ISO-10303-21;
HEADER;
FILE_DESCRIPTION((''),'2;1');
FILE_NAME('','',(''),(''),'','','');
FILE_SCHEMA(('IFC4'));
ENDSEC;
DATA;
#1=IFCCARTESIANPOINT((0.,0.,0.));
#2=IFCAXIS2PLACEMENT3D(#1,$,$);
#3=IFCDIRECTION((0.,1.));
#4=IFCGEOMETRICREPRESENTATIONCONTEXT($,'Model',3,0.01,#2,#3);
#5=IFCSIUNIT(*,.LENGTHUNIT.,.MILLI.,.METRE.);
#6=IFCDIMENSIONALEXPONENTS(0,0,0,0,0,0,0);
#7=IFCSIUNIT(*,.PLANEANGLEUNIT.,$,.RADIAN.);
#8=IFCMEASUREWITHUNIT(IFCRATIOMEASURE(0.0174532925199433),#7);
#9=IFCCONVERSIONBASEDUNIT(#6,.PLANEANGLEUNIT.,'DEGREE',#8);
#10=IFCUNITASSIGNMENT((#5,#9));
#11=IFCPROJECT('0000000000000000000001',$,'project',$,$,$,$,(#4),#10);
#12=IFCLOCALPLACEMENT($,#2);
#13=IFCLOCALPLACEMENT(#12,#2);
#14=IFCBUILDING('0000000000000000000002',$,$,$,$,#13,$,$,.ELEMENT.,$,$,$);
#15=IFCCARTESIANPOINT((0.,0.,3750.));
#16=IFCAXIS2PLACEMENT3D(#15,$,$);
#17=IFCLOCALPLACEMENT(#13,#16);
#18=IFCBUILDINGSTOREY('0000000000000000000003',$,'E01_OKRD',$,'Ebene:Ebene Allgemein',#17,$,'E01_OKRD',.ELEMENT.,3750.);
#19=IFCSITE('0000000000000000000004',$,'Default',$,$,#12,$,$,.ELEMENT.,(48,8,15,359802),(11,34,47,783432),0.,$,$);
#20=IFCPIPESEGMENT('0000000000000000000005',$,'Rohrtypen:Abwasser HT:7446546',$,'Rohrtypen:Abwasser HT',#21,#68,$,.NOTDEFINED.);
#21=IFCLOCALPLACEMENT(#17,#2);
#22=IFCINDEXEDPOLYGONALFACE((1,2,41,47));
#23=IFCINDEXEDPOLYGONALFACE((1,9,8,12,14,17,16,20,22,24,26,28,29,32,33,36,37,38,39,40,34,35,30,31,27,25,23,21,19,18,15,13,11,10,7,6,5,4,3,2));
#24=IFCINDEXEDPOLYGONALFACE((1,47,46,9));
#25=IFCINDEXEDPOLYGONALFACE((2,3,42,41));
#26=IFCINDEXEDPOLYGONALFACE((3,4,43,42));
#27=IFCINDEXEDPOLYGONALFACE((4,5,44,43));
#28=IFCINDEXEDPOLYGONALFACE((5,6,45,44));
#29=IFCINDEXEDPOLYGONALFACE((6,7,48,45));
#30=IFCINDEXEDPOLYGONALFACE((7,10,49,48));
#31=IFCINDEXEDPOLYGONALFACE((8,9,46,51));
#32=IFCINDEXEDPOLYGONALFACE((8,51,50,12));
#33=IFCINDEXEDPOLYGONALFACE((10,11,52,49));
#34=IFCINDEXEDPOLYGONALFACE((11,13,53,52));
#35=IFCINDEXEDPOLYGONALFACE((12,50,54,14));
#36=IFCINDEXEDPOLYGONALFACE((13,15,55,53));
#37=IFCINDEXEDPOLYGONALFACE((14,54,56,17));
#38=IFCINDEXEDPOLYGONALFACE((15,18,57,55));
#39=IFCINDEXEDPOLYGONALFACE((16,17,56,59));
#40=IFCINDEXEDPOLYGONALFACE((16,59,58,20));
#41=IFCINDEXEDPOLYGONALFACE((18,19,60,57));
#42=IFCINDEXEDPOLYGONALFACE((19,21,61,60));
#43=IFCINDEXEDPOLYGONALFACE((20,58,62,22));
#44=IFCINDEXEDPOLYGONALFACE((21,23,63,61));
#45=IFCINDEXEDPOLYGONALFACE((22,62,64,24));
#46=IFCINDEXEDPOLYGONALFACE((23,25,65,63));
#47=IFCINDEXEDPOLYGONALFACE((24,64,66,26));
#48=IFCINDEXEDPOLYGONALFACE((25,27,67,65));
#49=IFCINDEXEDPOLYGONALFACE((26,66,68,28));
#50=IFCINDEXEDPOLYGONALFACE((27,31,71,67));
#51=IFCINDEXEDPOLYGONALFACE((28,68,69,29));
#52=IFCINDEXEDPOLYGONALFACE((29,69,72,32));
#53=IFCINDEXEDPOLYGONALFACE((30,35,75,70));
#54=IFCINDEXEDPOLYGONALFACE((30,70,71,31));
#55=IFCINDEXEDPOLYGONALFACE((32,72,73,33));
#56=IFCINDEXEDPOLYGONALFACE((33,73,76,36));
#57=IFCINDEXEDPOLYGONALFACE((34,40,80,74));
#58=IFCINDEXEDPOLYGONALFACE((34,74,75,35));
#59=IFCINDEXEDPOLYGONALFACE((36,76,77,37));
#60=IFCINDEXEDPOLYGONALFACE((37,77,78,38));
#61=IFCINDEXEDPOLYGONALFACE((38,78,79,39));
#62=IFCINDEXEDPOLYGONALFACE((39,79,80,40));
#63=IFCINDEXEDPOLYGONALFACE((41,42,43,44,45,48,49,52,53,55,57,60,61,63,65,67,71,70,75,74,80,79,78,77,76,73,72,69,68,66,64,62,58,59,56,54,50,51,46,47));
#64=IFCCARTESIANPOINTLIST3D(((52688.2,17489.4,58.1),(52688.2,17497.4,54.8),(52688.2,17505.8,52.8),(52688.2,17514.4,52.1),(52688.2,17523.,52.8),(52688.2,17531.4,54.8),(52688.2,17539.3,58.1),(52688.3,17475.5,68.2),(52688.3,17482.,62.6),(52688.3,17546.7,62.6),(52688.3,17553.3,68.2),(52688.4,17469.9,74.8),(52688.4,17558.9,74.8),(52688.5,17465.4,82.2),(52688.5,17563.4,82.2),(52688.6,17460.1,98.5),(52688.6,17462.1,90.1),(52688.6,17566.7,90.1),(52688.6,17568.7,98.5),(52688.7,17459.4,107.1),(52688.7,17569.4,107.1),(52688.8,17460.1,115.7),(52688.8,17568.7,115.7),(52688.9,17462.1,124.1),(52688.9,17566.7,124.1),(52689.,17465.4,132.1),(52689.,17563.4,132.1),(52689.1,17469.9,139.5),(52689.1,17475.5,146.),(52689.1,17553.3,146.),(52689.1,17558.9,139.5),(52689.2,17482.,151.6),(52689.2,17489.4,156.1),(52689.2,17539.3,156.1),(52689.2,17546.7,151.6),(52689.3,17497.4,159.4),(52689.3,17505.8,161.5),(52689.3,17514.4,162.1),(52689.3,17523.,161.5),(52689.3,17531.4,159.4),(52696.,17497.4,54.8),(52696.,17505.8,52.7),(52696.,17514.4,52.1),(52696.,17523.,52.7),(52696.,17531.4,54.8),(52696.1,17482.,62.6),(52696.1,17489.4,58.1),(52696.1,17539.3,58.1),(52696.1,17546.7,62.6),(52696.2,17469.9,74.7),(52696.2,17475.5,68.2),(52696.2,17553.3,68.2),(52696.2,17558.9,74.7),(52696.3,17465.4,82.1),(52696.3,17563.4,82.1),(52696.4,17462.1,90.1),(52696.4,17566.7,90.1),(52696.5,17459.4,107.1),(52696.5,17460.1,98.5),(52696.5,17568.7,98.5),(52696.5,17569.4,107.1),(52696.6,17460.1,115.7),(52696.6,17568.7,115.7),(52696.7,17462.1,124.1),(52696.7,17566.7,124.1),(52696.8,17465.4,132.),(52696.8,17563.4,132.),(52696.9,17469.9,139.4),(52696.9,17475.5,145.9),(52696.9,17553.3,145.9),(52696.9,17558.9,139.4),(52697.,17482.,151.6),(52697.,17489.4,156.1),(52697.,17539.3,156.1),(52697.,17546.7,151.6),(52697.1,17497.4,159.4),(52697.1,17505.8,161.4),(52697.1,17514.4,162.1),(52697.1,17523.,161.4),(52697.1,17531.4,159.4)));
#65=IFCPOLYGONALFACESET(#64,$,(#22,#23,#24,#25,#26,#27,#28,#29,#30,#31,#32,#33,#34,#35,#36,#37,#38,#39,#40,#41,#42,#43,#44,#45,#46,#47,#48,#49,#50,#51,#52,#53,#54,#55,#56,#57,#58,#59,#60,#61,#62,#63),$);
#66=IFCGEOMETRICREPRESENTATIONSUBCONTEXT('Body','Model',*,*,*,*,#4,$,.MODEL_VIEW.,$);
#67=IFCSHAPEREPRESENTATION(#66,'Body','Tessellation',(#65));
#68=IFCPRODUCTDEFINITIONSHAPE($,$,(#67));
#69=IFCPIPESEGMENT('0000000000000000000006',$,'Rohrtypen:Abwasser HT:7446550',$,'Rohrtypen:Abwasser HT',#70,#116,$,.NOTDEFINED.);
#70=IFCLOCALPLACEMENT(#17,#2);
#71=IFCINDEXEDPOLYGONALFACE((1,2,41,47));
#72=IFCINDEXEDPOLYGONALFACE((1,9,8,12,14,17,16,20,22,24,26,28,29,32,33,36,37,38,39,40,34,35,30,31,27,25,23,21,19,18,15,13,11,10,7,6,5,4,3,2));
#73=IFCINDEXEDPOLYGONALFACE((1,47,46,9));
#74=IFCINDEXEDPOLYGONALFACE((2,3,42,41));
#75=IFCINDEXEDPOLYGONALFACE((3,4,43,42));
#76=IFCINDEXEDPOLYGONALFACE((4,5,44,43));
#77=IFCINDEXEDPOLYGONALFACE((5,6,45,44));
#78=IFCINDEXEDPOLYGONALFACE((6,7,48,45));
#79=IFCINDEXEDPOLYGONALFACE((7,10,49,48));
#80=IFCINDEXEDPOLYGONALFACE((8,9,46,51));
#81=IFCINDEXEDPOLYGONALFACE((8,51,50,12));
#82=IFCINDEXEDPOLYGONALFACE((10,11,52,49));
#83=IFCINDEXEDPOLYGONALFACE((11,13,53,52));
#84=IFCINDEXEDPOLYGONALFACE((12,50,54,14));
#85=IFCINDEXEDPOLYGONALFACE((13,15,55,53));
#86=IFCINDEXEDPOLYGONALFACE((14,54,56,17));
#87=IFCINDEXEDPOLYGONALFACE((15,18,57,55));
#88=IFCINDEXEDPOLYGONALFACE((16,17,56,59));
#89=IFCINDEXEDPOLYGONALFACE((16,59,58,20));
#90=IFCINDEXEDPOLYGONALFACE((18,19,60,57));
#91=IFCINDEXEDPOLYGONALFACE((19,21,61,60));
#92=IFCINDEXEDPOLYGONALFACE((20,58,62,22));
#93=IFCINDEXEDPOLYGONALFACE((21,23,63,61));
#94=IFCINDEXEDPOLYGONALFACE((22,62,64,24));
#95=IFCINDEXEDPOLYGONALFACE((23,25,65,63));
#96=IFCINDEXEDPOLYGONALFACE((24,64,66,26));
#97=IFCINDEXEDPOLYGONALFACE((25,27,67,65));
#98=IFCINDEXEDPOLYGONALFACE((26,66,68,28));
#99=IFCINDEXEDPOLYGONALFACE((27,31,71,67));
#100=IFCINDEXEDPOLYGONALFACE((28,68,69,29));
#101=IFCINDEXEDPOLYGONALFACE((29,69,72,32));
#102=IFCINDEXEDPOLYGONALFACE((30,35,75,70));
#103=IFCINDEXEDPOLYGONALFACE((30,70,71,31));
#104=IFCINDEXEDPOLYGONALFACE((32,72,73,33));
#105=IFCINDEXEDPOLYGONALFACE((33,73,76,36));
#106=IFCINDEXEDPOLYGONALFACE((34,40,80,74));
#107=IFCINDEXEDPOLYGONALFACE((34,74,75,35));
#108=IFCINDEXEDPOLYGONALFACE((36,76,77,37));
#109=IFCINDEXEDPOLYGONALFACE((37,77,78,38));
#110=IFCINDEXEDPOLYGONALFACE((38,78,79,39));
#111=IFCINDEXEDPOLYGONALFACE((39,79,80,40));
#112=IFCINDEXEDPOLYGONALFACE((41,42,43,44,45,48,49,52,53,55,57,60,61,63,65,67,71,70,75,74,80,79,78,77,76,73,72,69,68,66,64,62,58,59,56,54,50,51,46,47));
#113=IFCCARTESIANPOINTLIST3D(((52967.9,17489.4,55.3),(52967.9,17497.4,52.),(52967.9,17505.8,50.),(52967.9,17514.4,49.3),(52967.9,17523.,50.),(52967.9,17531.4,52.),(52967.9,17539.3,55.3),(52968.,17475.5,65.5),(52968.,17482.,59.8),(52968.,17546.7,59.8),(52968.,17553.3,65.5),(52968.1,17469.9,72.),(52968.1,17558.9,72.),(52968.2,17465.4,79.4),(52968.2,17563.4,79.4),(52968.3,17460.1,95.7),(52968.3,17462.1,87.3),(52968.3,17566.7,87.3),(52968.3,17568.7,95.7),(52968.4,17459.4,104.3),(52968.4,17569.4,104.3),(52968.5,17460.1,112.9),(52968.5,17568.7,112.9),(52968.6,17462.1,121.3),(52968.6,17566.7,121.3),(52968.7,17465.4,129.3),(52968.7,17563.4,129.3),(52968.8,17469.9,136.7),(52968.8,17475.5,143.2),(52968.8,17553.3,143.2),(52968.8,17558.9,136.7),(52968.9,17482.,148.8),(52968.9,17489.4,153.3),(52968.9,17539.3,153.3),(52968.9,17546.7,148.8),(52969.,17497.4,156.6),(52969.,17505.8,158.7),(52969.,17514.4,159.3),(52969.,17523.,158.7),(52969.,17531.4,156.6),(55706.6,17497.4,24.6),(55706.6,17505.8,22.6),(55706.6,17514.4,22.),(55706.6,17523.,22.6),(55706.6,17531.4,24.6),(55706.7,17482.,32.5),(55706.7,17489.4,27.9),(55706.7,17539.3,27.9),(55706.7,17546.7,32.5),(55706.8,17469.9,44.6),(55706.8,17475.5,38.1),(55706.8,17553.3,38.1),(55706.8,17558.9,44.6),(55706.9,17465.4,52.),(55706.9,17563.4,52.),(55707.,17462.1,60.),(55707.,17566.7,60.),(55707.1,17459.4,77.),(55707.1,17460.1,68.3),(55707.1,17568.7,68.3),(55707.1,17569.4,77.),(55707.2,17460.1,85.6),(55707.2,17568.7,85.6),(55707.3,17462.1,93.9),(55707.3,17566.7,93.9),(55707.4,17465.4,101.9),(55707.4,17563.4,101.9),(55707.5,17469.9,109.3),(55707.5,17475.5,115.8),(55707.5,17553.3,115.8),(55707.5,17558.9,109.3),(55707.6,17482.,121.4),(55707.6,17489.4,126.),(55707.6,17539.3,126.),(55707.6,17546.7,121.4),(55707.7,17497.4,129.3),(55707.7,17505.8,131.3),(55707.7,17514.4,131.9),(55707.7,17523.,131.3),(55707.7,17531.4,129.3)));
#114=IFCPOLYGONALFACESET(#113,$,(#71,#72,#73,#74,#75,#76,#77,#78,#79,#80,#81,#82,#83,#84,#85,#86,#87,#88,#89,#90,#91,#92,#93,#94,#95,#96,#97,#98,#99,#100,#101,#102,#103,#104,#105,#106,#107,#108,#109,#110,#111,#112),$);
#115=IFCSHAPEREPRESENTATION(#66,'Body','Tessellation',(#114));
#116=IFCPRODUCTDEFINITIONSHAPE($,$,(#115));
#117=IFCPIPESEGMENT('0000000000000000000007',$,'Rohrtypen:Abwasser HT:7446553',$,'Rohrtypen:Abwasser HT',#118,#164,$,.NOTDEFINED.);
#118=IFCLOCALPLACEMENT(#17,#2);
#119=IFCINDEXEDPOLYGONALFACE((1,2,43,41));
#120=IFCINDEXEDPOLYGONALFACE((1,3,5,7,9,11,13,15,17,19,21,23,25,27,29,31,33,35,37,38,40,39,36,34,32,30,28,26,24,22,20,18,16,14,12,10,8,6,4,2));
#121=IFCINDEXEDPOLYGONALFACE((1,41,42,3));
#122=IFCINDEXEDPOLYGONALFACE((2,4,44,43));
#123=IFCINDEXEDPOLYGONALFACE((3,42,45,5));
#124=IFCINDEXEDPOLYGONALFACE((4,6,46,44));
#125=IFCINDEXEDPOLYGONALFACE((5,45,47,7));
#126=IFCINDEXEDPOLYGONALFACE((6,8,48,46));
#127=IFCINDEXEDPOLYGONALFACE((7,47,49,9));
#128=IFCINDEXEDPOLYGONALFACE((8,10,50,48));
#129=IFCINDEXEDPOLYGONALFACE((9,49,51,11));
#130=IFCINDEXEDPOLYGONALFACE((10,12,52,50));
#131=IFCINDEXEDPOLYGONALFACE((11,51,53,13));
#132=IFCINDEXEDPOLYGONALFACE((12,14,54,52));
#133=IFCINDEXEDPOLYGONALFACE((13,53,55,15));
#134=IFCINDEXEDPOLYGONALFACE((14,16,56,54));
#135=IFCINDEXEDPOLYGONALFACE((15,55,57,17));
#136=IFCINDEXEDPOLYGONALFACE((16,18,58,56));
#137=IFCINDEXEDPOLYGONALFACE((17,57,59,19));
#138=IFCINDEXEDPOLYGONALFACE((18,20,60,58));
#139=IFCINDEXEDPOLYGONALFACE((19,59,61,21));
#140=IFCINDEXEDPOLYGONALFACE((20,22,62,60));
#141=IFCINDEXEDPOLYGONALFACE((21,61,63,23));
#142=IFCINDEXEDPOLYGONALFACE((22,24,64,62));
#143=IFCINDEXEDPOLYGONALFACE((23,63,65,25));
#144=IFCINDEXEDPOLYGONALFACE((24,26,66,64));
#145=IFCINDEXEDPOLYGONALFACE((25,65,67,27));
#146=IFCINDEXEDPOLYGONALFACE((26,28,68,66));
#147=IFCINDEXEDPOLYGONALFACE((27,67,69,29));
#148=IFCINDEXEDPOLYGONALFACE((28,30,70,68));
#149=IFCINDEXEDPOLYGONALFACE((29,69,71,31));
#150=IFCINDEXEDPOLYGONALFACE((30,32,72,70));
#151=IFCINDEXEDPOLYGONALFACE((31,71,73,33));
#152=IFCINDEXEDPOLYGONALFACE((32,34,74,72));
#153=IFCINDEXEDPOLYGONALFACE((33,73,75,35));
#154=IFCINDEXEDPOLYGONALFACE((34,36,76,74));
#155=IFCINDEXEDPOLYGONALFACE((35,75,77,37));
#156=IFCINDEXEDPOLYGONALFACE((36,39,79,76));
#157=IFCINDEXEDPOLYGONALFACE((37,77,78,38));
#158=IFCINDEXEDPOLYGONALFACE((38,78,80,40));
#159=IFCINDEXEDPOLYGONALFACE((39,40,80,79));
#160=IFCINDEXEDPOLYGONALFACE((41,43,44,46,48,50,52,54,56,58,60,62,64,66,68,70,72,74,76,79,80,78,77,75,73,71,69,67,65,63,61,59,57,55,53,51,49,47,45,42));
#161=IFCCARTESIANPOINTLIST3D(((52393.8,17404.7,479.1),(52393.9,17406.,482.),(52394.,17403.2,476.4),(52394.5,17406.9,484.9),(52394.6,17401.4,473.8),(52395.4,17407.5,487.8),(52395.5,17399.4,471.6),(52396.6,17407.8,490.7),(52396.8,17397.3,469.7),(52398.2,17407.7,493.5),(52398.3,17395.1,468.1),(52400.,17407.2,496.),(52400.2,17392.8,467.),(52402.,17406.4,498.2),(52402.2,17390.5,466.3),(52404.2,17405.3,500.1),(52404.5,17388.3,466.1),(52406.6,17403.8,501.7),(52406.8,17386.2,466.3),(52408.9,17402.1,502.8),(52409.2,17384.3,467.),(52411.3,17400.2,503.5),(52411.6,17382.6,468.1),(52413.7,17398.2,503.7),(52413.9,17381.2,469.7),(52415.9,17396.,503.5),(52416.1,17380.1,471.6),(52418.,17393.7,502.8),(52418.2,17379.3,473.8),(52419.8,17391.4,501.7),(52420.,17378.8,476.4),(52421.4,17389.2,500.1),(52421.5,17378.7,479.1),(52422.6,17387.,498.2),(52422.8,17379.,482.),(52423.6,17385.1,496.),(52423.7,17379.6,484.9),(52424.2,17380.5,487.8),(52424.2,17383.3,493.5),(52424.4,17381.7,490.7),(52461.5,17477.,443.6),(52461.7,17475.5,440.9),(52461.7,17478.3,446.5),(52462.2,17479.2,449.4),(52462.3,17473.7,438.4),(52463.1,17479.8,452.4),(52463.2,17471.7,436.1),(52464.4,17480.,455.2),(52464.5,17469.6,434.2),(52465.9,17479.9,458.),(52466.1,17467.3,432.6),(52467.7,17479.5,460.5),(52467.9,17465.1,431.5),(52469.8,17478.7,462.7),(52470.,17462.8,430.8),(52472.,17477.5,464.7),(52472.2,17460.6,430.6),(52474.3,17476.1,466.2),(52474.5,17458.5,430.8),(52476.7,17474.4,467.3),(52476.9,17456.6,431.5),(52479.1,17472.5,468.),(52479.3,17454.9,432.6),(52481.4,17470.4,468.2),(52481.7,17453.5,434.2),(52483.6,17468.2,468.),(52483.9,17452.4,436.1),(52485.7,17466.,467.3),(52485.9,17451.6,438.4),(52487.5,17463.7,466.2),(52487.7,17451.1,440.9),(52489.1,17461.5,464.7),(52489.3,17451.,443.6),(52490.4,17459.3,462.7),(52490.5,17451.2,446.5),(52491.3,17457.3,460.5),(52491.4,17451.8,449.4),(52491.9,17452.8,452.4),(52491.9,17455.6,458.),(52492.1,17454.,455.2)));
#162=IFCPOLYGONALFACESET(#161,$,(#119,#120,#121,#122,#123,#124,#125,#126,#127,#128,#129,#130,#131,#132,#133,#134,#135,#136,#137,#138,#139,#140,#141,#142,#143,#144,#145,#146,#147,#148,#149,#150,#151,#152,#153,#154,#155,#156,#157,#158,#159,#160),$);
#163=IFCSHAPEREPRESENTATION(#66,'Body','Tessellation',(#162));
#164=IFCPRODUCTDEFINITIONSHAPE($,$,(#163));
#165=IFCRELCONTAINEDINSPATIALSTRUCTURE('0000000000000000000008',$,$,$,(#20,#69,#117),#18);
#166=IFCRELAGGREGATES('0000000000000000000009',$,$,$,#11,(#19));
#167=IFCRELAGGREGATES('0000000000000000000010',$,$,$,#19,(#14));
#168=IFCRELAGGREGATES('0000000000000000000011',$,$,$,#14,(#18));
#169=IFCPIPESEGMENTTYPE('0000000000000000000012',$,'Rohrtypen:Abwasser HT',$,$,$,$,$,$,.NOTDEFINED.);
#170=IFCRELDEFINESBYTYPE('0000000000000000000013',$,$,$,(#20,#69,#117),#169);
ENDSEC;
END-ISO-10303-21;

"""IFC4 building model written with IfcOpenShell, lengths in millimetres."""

from ifc_helpers import new_model, entity, si_unit, converted_unit, direction, frame, origin, place, context, subcontext, project, spatial, indexed_curve, outline, extrude, type_object, element, save


model = new_model("IFC4")

# Units and contexts
model_context = context("Model", 3, precision=0.01, world=origin(), true_north=direction((0.0, 1.0)))
body_context = subcontext(model_context, "Body", "Model", "MODEL_VIEW")
ifc_project = project(units=[si_unit("LENGTHUNIT", "METRE", prefix="MILLI"), converted_unit("PLANEANGLEUNIT", "DEGREE", entity("IfcRatioMeasure", 0.0174532925199433), si_unit("PLANEANGLEUNIT", "RADIAN"), dimensions=[0, 0, 0, 0, 0, 0, 0])], contexts=[model_context])

# Site, building, storey
site_placement = place(None, origin())
site = spatial("IfcSite", under=ifc_project, at=site_placement, Name="Default", CompositionType="ELEMENT", RefLatitude=(48, 8, 15, 359802), RefLongitude=(11, 34, 47, 783432), RefElevation=0.0)
building_placement = place(site_placement, origin())
building = spatial("IfcBuilding", under=site, at=building_placement, CompositionType="ELEMENT")
storey_placement = place(building_placement, frame((0.0, 0.0, 3750.0)))
storey = spatial("IfcBuildingStorey", under=building, at=storey_placement, Name="E01_OKRD", ObjectType="Ebene:Ebene Allgemein", LongName="E01_OKRD", CompositionType="ELEMENT", Elevation=3750.0)

# Pipe segments
pipe_segment_type_1 = type_object("IfcPipeSegmentType", Name="Rohrtypen:Abwasser HT", PredefinedType="NOTDEFINED")
pipe_segment_1_placement = place(storey_placement, origin())
element("IfcPipeSegment", 1, at=pipe_segment_1_placement, inside=storey, type_object=pipe_segment_type_1, Name="Rohrtypen:Abwasser HT:7446546", ObjectType="Rohrtypen:Abwasser HT", PredefinedType="NOTDEFINED", context=body_context, shape_type="SweptSolid", body=[
    extrude(outline(indexed_curve([(55.0, 0.0), (54.3, 8.6), (52.3, 17.0), (49.0, 25.0), (44.5, 32.3), (38.9, 38.9), (32.3, 44.5), (25.0, 49.0), (17.0, 52.3), (8.6, 54.3), (0.0, 55.0), (-8.6, 54.3), (-17.0, 52.3), (-25.0, 49.0), (-32.3, 44.5), (-38.9, 38.9), (-44.5, 32.3), (-49.0, 25.0), (-52.3, 17.0), (-54.3, 8.6), (-55.0, 0.0), (-54.3, -8.6), (-52.3, -17.0), (-49.0, -25.0), (-44.5, -32.3), (-38.9, -38.9), (-32.3, -44.5), (-25.0, -49.0), (-17.0, -52.3), (-8.6, -54.3), (0.0, -55.0), (8.6, -54.3), (17.0, -52.3), (25.0, -49.0), (32.3, -44.5), (38.9, -38.9), (44.5, -32.3), (49.0, -25.0), (52.3, -17.0), (54.3, -8.6), (55.0, 0.0)], self_intersect=False)), frame((52696.5, 17514.4, 107.1), z_axis=(-0.99995, 0.0, 0.01), x_axis=(0.0, 1.0, 0.0)), (0.0, 0.0, 1.0), 7.8),
])
pipe_segment_2_placement = place(storey_placement, origin())
element("IfcPipeSegment", 2, at=pipe_segment_2_placement, inside=storey, type_object=pipe_segment_type_1, Name="Rohrtypen:Abwasser HT:7446550", ObjectType="Rohrtypen:Abwasser HT", PredefinedType="NOTDEFINED", context=body_context, shape_type="SweptSolid", body=[
    extrude(outline(indexed_curve([(55.0, 0.0), (54.3, 8.6), (52.3, 17.0), (49.0, 25.0), (44.5, 32.3), (38.9, 38.9), (32.3, 44.5), (25.0, 49.0), (17.0, 52.3), (8.6, 54.3), (0.0, 55.0), (-8.6, 54.3), (-17.0, 52.3), (-25.0, 49.0), (-32.3, 44.5), (-38.9, 38.9), (-44.5, 32.3), (-49.0, 25.0), (-52.3, 17.0), (-54.3, 8.6), (-55.0, 0.0), (-54.3, -8.6), (-52.3, -17.0), (-49.0, -25.0), (-44.5, -32.3), (-38.9, -38.9), (-32.3, -44.5), (-25.0, -49.0), (-17.0, -52.3), (-8.6, -54.3), (0.0, -55.0), (8.6, -54.3), (17.0, -52.3), (25.0, -49.0), (32.3, -44.5), (38.9, -38.9), (44.5, -32.3), (49.0, -25.0), (52.3, -17.0), (54.3, -8.6), (55.0, 0.0)], self_intersect=False)), frame((52968.4, 17514.4, 104.3), z_axis=(0.99995, 0.0, -0.01), x_axis=(0.0, 1.0, 0.0)), (0.0, 0.0, 1.0), 2738.9),
])
pipe_segment_3_placement = place(storey_placement, origin())
element("IfcPipeSegment", 3, at=pipe_segment_3_placement, inside=storey, type_object=pipe_segment_type_1, Name="Rohrtypen:Abwasser HT:7446553", ObjectType="Rohrtypen:Abwasser HT", PredefinedType="NOTDEFINED", context=body_context, shape_type="SweptSolid", body=[
    extrude(outline(indexed_curve([(20.0, 0.0), (19.8, 3.1), (19.0, 6.2), (17.8, 9.1), (16.2, 11.8), (14.1, 14.1), (11.8, 16.2), (9.1, 17.8), (6.2, 19.0), (3.1, 19.8), (0.0, 20.0), (-3.1, 19.8), (-6.2, 19.0), (-9.1, 17.8), (-11.8, 16.2), (-14.1, 14.1), (-16.2, 11.8), (-17.8, 9.1), (-19.0, 6.2), (-19.8, 3.1), (-20.0, 0.0), (-19.8, -3.1), (-19.0, -6.2), (-17.8, -9.1), (-16.2, -11.8), (-14.1, -14.1), (-11.8, -16.2), (-9.1, -17.8), (-6.2, -19.0), (-3.1, -19.8), (0.0, -20.0), (3.1, -19.8), (6.2, -19.0), (9.1, -17.8), (11.8, -16.2), (14.1, -14.1), (16.2, -11.8), (17.8, -9.1), (19.0, -6.2), (19.8, -3.1), (20.0, 0.0)], self_intersect=False)), frame((52476.8, 17465.5, 449.4), z_axis=(-0.643762, -0.686922, 0.337205), x_axis=(-0.729658, 0.683813, 0.0)), (0.0, 0.0, 1.0), 105.2),
])

save(model, "model.ifc")
